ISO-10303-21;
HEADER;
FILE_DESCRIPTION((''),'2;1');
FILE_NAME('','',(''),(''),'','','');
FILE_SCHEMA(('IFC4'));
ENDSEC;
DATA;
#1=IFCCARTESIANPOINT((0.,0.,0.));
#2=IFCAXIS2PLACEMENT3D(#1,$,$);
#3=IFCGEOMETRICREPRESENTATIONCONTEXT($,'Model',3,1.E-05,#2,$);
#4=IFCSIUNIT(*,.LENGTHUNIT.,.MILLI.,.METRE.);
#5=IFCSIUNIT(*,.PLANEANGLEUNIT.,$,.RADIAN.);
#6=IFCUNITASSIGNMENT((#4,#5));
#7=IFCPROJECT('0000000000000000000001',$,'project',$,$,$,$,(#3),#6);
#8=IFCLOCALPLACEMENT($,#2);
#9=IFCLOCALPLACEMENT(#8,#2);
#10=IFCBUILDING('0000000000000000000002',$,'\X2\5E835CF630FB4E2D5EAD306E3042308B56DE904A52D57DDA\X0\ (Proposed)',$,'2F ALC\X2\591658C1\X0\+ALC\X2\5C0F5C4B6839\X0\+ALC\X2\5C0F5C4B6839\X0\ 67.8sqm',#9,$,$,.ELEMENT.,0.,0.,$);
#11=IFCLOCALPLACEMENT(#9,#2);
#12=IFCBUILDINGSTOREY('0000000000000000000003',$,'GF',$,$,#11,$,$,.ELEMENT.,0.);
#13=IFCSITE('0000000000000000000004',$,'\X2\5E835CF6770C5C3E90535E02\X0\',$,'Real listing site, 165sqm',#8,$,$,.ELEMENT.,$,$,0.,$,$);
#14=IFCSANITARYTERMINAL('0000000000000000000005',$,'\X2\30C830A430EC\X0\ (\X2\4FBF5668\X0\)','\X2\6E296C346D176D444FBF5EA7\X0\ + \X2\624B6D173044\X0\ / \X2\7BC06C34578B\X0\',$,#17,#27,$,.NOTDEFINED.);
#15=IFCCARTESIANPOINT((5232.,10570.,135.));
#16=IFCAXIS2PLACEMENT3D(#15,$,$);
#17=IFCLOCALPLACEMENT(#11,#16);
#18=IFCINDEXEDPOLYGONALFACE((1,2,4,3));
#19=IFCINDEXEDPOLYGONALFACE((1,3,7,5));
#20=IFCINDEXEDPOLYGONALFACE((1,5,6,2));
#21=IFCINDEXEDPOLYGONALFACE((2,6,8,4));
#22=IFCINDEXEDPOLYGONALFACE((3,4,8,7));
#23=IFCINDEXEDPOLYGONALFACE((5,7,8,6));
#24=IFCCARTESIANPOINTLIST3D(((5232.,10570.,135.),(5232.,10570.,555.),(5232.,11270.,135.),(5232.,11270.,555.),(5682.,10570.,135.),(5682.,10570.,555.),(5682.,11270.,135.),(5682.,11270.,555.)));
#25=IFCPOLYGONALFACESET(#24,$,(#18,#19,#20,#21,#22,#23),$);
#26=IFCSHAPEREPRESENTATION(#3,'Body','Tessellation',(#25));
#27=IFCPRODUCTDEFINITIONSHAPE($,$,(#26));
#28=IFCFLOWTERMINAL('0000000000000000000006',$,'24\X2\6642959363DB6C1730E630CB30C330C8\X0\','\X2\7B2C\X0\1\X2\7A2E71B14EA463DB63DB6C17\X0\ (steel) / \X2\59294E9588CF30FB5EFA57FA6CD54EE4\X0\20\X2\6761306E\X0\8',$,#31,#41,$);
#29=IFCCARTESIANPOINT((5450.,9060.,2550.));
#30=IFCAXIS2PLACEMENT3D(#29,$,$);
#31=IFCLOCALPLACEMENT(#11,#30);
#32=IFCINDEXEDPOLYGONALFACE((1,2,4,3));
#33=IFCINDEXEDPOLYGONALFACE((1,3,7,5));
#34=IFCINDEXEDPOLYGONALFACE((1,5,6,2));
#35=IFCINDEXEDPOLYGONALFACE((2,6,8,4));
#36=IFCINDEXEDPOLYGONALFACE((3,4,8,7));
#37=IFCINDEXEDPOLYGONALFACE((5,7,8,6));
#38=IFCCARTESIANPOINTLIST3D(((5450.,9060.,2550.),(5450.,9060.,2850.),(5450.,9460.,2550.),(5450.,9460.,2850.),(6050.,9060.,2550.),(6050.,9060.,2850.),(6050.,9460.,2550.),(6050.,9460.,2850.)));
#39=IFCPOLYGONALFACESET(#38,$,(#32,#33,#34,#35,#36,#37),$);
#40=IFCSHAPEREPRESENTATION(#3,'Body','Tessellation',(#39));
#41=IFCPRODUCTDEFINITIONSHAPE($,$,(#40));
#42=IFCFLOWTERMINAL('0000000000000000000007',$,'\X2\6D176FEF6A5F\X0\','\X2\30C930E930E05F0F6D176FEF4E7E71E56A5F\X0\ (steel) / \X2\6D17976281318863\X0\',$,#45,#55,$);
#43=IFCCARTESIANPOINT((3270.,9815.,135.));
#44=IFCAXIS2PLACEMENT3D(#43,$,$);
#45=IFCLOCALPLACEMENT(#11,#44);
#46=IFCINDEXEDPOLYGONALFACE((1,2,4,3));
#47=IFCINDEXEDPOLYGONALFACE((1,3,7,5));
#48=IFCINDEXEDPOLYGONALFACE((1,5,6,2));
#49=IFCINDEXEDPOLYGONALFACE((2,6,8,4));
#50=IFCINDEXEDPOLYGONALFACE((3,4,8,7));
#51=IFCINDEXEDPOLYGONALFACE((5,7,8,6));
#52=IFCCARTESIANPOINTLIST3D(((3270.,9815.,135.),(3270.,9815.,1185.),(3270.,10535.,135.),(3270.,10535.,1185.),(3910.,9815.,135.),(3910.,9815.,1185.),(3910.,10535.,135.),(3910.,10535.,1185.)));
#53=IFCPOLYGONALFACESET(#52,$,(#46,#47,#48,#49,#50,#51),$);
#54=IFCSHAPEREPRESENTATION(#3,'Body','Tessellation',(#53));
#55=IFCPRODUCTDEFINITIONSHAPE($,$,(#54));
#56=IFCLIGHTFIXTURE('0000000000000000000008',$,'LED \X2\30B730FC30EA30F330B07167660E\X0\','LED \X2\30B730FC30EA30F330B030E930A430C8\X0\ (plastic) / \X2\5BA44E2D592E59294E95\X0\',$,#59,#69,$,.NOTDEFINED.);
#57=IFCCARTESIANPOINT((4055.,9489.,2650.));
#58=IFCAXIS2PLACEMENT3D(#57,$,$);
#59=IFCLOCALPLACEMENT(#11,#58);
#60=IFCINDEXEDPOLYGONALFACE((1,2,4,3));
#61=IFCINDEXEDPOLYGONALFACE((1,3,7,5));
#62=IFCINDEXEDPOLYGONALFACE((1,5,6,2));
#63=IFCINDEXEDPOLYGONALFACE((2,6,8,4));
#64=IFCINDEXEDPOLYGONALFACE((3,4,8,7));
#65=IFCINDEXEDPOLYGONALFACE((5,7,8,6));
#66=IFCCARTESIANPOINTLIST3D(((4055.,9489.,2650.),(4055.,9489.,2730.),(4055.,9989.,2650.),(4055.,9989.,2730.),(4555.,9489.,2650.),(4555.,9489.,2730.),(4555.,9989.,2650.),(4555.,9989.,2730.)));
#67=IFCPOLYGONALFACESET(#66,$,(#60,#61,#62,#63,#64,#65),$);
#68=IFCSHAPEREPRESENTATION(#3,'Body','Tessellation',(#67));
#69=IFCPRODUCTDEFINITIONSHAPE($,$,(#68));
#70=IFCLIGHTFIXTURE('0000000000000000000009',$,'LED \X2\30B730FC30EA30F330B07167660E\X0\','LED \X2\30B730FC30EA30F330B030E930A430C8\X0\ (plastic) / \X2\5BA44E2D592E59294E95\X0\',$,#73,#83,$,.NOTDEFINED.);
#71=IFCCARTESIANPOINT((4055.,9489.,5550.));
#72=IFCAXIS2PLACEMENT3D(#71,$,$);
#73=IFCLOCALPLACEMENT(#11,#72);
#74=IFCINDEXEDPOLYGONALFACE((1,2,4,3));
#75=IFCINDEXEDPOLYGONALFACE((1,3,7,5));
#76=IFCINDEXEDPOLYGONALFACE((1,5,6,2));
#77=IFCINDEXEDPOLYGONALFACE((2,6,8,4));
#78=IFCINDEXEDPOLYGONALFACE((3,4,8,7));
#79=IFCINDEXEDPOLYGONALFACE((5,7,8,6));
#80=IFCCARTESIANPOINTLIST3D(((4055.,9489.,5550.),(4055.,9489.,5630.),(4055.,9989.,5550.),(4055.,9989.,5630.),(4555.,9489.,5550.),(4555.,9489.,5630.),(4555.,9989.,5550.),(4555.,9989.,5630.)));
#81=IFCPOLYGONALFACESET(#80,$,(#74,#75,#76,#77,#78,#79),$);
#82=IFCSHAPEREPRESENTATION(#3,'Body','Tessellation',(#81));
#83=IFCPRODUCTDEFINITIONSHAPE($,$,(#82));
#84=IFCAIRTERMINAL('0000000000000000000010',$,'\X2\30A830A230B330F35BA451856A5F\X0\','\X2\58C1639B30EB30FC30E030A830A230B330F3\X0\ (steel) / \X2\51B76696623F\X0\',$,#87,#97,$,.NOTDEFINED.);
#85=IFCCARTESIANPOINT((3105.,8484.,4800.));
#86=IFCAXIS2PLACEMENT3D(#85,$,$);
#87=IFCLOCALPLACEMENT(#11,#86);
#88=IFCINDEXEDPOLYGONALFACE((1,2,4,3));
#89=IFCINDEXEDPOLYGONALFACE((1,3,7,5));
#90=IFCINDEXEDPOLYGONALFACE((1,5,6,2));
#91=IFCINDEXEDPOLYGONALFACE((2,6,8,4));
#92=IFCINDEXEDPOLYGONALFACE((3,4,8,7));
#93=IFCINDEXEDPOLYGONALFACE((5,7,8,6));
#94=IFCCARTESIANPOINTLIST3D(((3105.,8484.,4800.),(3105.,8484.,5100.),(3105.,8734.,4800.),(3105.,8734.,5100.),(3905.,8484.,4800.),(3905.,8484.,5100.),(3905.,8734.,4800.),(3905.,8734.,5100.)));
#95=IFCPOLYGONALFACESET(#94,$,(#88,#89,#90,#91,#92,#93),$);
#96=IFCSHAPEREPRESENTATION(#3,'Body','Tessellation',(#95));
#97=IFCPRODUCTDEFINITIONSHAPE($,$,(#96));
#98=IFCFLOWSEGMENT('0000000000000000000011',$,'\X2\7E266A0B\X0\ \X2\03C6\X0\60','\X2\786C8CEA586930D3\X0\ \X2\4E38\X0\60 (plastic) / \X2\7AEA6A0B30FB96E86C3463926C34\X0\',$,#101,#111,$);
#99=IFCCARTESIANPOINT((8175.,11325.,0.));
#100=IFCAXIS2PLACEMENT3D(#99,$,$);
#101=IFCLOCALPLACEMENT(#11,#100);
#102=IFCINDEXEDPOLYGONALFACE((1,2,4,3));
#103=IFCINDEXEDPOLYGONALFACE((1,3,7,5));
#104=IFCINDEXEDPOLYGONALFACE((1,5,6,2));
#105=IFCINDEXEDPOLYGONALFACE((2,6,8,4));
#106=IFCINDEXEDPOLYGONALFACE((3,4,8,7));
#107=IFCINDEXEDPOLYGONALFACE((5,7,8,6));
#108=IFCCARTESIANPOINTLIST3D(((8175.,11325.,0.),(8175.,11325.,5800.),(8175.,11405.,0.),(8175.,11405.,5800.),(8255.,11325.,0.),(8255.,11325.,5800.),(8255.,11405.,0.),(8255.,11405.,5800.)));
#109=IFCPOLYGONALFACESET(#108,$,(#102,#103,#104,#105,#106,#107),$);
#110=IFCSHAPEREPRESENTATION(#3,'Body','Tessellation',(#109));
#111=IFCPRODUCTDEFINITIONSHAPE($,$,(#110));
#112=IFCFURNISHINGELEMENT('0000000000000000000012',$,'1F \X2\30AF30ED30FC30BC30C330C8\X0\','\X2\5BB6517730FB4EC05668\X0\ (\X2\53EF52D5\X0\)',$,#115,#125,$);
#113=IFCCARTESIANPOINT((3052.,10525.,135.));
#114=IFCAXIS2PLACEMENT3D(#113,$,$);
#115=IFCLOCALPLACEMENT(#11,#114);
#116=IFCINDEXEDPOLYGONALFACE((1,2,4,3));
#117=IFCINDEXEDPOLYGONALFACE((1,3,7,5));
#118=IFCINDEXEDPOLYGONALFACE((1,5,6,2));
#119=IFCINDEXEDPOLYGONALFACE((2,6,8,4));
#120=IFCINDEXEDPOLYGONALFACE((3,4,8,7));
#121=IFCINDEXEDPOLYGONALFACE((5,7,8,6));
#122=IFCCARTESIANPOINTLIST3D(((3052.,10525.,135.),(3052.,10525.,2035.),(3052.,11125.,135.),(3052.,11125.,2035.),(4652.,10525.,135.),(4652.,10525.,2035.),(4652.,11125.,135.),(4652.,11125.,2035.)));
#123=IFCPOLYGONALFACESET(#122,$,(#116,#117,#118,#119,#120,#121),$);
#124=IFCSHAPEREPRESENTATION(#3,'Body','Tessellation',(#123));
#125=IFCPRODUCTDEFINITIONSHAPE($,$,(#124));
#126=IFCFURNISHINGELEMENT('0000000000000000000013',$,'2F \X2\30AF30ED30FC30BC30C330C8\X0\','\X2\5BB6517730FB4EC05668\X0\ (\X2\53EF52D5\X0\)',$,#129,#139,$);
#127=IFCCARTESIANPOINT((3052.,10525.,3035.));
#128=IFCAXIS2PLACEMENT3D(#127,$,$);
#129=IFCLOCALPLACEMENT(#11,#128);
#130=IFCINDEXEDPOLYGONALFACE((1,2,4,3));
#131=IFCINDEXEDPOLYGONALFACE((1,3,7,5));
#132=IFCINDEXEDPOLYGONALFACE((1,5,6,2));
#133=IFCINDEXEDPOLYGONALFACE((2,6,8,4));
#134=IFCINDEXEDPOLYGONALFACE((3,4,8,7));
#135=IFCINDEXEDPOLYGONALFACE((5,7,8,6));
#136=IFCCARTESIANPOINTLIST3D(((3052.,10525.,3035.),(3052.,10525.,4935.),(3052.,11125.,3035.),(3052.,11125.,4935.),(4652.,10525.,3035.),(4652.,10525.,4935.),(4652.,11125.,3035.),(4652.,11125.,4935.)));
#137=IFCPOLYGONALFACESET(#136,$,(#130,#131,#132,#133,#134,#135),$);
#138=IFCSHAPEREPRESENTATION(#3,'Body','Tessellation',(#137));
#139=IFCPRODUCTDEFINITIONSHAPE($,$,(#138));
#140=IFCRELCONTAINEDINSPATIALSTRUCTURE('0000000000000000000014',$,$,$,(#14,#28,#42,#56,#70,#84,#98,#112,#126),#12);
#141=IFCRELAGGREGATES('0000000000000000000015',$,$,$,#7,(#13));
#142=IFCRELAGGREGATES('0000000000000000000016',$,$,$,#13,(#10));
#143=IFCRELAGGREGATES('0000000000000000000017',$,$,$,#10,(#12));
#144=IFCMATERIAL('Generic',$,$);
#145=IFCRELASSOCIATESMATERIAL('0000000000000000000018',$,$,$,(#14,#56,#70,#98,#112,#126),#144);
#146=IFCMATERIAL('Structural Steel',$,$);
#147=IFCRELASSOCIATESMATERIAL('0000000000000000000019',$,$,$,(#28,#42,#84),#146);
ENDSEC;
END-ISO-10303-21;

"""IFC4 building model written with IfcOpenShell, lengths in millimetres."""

from ifc_helpers import new_model, si_unit, frame, frame_2d, origin, place, context, project, spatial, rectangle, extrude, material, element, save


model = new_model("IFC4")

# Units and contexts
model_context = context("Model", 3, precision=1e-05, world=origin())
ifc_project = project(units=[si_unit("LENGTHUNIT", "METRE", prefix="MILLI"), si_unit("PLANEANGLEUNIT", "RADIAN")], contexts=[model_context])

# Site, building, storey
site_placement = place(None, origin())
site = spatial("IfcSite", under=ifc_project, at=site_placement, Name="広島県尾道市", ObjectType="Real listing site, 165sqm", CompositionType="ELEMENT", RefElevation=0.0)
building_placement = place(site_placement, origin())
building = spatial("IfcBuilding", under=site, at=building_placement, Name="広島・中庭のある回遊動線 (Proposed)", ObjectType="2F ALC外壁+ALC小屋根+ALC小屋根 67.8sqm", CompositionType="ELEMENT", ElevationOfRefHeight=0.0, ElevationOfTerrain=0.0)
storey_placement = place(building_placement, origin())
storey = spatial("IfcBuildingStorey", under=building, at=storey_placement, Name="GF", CompositionType="ELEMENT", Elevation=0.0)

# Sanitary terminal
ifc_material_1 = material(Name="Generic")
sanitary_terminal_1_placement = place(storey_placement, frame((5232.0, 10570.0, 135.0)))
element("IfcSanitaryTerminal", 1, at=sanitary_terminal_1_placement, inside=storey, material=ifc_material_1, Name="トイレ (便器)", Description="温水洗浄便座 + 手洗い / 節水型", PredefinedType="NOTDEFINED", context=model_context, shape_type="SweptSolid", body=[
    extrude(rectangle(XDim=450.0, YDim=700.0, at=frame_2d((225.0, 350.0))), frame((5232.0, 10570.0, 135.0)), (0.0, 0.0, 1.0), 420.0),
])

# Flow terminals
ifc_material_2 = material(Name="Structural Steel")
flow_terminal_1_placement = place(storey_placement, frame((5450.0, 9060.0, 2550.0)))
element("IfcFlowTerminal", 2, at=flow_terminal_1_placement, inside=storey, material=ifc_material_2, Name="24時間換気ユニット", Description="第1種熱交換換気 (steel) / 天井裏・建基法令20条の8", context=model_context, shape_type="SweptSolid", body=[
    extrude(rectangle(XDim=600.0, YDim=400.0, at=frame_2d((300.0, 200.0))), frame((5450.0, 9060.0, 2550.0)), (0.0, 0.0, 1.0), 300.0),
])
flow_terminal_2_placement = place(storey_placement, frame((3270.0, 9815.0, 135.0)))
element("IfcFlowTerminal", 3, at=flow_terminal_2_placement, inside=storey, material=ifc_material_2, Name="洗濯機", Description="ドラム式洗濯乾燥機 (steel) / 洗面脱衣", context=model_context, shape_type="SweptSolid", body=[
    extrude(rectangle(XDim=640.0, YDim=720.0, at=frame_2d((320.0, 360.0))), frame((3270.0, 9815.0, 135.0)), (0.0, 0.0, 1.0), 1050.0),
])

# Light fixtures
light_fixture_1_placement = place(storey_placement, frame((4055.0, 9489.0, 2650.0)))
element("IfcLightFixture", 4, at=light_fixture_1_placement, inside=storey, material=ifc_material_1, Name="LED シーリング照明", Description="LED シーリングライト (plastic) / 室中央天井", PredefinedType="NOTDEFINED", context=model_context, shape_type="SweptSolid", body=[
    extrude(rectangle(XDim=500.0, YDim=500.0, at=frame_2d((250.0, 250.0))), frame((4055.0, 9489.0, 2650.0)), (0.0, 0.0, 1.0), 80.0),
])
light_fixture_2_placement = place(storey_placement, frame((4055.0, 9489.0, 5550.0)))
element("IfcLightFixture", 5, at=light_fixture_2_placement, inside=storey, material=ifc_material_1, Name="LED シーリング照明", Description="LED シーリングライト (plastic) / 室中央天井", PredefinedType="NOTDEFINED", context=model_context, shape_type="SweptSolid", body=[
    extrude(rectangle(XDim=500.0, YDim=500.0, at=frame_2d((250.0, 250.0))), frame((4055.0, 9489.0, 5550.0)), (0.0, 0.0, 1.0), 80.0),
])

# Air terminal
air_terminal_placement = place(storey_placement, frame((3105.0, 8484.0, 4800.0)))
element("IfcAirTerminal", 6, at=air_terminal_placement, inside=storey, material=ifc_material_2, Name="エアコン室内機", Description="壁掛ルームエアコン (steel) / 冷暖房", PredefinedType="NOTDEFINED", context=model_context, shape_type="SweptSolid", body=[
    extrude(rectangle(XDim=800.0, YDim=250.0, at=frame_2d((400.0, 125.0))), frame((3105.0, 8484.0, 4800.0)), (0.0, 0.0, 1.0), 300.0),
])

# Flow segment
flow_segment_placement = place(storey_placement, frame((8175.0, 11325.0, 0.0)))
element("IfcFlowSegment", 7, at=flow_segment_placement, inside=storey, material=ifc_material_1, Name="縦樋 φ60", Description="硬質塩ビ 丸60 (plastic) / 竪樋・雨水排水", context=model_context, shape_type="SweptSolid", body=[
    extrude(rectangle(XDim=80.0, YDim=80.0, at=frame_2d((40.0, 40.0))), frame((8175.0, 11325.0, 0.0)), (0.0, 0.0, 1.0), 5800.0),
])

# Furnishing elements
furnishing_1_placement = place(storey_placement, frame((3052.0, 10525.0, 135.0)))
element("IfcFurnishingElement", 8, at=furnishing_1_placement, inside=storey, material=ifc_material_1, Name="1F クローゼット", Description="家具・什器 (可動)", context=model_context, shape_type="SweptSolid", body=[
    extrude(rectangle(XDim=1600.0, YDim=600.0, at=frame_2d((800.0, 300.0))), frame((3052.0, 10525.0, 135.0)), (0.0, 0.0, 1.0), 1900.0),
])
furnishing_2_placement = place(storey_placement, frame((3052.0, 10525.0, 3035.0)))
element("IfcFurnishingElement", 9, at=furnishing_2_placement, inside=storey, material=ifc_material_1, Name="2F クローゼット", Description="家具・什器 (可動)", context=model_context, shape_type="SweptSolid", body=[
    extrude(rectangle(XDim=1600.0, YDim=600.0, at=frame_2d((800.0, 300.0))), frame((3052.0, 10525.0, 3035.0)), (0.0, 0.0, 1.0), 1900.0),
])

save(model, "model.ifc")
